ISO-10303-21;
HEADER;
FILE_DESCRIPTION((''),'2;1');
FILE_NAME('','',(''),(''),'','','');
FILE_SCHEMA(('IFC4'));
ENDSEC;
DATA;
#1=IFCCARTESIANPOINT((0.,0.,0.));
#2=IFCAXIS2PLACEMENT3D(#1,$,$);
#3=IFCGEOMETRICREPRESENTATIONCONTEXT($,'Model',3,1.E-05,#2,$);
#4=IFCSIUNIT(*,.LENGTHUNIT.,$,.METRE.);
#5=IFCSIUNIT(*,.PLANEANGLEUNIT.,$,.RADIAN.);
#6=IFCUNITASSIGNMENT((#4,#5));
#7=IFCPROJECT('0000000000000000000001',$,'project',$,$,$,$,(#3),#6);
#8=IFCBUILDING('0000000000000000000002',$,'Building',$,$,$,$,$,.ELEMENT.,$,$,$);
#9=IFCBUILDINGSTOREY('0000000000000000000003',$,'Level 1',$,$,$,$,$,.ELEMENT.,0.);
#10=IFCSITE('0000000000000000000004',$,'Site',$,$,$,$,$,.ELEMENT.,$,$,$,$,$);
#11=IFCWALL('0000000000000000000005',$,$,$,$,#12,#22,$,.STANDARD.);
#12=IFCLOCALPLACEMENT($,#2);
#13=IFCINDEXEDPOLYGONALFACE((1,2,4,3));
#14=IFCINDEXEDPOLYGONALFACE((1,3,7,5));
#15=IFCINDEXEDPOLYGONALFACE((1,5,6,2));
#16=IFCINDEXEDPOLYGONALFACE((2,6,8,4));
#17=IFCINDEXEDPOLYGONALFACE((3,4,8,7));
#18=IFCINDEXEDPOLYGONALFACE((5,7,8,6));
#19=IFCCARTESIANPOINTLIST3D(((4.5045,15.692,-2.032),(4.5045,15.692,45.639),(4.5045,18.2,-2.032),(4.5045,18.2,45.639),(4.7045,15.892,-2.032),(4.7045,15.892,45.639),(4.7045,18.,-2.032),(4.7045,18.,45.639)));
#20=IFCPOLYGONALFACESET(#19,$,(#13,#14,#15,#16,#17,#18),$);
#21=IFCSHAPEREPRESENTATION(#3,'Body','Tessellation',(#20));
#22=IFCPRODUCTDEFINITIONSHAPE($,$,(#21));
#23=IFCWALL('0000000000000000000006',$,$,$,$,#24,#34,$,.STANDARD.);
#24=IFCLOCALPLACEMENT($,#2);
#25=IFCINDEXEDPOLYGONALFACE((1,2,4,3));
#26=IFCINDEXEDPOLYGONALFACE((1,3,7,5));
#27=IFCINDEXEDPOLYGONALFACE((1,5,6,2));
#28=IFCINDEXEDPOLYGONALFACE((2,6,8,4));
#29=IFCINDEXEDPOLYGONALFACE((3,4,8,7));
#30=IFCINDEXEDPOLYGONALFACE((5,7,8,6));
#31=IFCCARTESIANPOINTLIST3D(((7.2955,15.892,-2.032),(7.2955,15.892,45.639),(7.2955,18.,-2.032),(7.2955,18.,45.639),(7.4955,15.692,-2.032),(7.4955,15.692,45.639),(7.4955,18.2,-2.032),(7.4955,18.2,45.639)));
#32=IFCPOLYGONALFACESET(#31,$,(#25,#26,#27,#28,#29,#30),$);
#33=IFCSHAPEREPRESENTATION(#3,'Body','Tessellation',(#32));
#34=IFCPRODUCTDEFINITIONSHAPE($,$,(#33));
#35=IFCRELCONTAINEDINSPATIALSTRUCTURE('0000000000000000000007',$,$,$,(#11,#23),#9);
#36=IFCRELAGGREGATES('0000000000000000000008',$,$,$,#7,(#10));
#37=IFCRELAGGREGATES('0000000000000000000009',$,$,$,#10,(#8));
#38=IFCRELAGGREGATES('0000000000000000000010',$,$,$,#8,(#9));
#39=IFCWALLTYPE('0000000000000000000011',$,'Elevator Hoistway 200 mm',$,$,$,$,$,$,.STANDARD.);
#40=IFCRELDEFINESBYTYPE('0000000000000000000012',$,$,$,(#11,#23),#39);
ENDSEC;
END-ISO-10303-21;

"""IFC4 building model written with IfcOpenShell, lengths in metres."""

from ifc_helpers import new_model, si_unit, frame, origin, place, context, project, spatial, polyline, outline, extrude, type_object, element, save


model = new_model("IFC4")

# Units and contexts
model_context = context("Model", 3, precision=1e-05, world=origin())
ifc_project = project(units=[si_unit("LENGTHUNIT", "METRE"), si_unit("PLANEANGLEUNIT", "RADIAN")], contexts=[model_context])

# Site, building, storey
site = spatial("IfcSite", under=ifc_project, Name="Site", CompositionType="ELEMENT")
building = spatial("IfcBuilding", under=site, Name="Building", CompositionType="ELEMENT")
storey = spatial("IfcBuildingStorey", under=building, Name="Level 1", CompositionType="ELEMENT", Elevation=0.0)

# Shared definitions
wall_type = type_object("IfcWallType", Name="Elevator Hoistway 200 mm", PredefinedType="STANDARD")

# Walls
wall_1_placement = place(None, frame((4.6045, 18.1, -2.032), z_axis=(0.0, 0.0, 1.0), x_axis=(0.0, -1.0, 0.0)))
element("IfcWall", 1, at=wall_1_placement, inside=storey, type_object=wall_type, PredefinedType="STANDARD", context=model_context, shape_type="SweptSolid", body=[
    extrude(outline(polyline([(-0.1, -0.1), (2.408, -0.1), (2.208, 0.1), (0.1, 0.1), (-0.1, -0.1)])), origin(), (0.0, 0.0, 1.0), 47.671),
])
wall_2_placement = place(None, frame((7.3955, 15.792, -2.032), z_axis=(0.0, 0.0, 1.0), x_axis=(0.0, 1.0, 0.0)))
element("IfcWall", 2, at=wall_2_placement, inside=storey, type_object=wall_type, PredefinedType="STANDARD", context=model_context, shape_type="SweptSolid", body=[
    extrude(outline(polyline([(-0.1, -0.1), (2.408, -0.1), (2.208, 0.1), (0.1, 0.1), (-0.1, -0.1)])), origin(), (0.0, 0.0, 1.0), 47.671),
])

save(model, "model.ifc")
